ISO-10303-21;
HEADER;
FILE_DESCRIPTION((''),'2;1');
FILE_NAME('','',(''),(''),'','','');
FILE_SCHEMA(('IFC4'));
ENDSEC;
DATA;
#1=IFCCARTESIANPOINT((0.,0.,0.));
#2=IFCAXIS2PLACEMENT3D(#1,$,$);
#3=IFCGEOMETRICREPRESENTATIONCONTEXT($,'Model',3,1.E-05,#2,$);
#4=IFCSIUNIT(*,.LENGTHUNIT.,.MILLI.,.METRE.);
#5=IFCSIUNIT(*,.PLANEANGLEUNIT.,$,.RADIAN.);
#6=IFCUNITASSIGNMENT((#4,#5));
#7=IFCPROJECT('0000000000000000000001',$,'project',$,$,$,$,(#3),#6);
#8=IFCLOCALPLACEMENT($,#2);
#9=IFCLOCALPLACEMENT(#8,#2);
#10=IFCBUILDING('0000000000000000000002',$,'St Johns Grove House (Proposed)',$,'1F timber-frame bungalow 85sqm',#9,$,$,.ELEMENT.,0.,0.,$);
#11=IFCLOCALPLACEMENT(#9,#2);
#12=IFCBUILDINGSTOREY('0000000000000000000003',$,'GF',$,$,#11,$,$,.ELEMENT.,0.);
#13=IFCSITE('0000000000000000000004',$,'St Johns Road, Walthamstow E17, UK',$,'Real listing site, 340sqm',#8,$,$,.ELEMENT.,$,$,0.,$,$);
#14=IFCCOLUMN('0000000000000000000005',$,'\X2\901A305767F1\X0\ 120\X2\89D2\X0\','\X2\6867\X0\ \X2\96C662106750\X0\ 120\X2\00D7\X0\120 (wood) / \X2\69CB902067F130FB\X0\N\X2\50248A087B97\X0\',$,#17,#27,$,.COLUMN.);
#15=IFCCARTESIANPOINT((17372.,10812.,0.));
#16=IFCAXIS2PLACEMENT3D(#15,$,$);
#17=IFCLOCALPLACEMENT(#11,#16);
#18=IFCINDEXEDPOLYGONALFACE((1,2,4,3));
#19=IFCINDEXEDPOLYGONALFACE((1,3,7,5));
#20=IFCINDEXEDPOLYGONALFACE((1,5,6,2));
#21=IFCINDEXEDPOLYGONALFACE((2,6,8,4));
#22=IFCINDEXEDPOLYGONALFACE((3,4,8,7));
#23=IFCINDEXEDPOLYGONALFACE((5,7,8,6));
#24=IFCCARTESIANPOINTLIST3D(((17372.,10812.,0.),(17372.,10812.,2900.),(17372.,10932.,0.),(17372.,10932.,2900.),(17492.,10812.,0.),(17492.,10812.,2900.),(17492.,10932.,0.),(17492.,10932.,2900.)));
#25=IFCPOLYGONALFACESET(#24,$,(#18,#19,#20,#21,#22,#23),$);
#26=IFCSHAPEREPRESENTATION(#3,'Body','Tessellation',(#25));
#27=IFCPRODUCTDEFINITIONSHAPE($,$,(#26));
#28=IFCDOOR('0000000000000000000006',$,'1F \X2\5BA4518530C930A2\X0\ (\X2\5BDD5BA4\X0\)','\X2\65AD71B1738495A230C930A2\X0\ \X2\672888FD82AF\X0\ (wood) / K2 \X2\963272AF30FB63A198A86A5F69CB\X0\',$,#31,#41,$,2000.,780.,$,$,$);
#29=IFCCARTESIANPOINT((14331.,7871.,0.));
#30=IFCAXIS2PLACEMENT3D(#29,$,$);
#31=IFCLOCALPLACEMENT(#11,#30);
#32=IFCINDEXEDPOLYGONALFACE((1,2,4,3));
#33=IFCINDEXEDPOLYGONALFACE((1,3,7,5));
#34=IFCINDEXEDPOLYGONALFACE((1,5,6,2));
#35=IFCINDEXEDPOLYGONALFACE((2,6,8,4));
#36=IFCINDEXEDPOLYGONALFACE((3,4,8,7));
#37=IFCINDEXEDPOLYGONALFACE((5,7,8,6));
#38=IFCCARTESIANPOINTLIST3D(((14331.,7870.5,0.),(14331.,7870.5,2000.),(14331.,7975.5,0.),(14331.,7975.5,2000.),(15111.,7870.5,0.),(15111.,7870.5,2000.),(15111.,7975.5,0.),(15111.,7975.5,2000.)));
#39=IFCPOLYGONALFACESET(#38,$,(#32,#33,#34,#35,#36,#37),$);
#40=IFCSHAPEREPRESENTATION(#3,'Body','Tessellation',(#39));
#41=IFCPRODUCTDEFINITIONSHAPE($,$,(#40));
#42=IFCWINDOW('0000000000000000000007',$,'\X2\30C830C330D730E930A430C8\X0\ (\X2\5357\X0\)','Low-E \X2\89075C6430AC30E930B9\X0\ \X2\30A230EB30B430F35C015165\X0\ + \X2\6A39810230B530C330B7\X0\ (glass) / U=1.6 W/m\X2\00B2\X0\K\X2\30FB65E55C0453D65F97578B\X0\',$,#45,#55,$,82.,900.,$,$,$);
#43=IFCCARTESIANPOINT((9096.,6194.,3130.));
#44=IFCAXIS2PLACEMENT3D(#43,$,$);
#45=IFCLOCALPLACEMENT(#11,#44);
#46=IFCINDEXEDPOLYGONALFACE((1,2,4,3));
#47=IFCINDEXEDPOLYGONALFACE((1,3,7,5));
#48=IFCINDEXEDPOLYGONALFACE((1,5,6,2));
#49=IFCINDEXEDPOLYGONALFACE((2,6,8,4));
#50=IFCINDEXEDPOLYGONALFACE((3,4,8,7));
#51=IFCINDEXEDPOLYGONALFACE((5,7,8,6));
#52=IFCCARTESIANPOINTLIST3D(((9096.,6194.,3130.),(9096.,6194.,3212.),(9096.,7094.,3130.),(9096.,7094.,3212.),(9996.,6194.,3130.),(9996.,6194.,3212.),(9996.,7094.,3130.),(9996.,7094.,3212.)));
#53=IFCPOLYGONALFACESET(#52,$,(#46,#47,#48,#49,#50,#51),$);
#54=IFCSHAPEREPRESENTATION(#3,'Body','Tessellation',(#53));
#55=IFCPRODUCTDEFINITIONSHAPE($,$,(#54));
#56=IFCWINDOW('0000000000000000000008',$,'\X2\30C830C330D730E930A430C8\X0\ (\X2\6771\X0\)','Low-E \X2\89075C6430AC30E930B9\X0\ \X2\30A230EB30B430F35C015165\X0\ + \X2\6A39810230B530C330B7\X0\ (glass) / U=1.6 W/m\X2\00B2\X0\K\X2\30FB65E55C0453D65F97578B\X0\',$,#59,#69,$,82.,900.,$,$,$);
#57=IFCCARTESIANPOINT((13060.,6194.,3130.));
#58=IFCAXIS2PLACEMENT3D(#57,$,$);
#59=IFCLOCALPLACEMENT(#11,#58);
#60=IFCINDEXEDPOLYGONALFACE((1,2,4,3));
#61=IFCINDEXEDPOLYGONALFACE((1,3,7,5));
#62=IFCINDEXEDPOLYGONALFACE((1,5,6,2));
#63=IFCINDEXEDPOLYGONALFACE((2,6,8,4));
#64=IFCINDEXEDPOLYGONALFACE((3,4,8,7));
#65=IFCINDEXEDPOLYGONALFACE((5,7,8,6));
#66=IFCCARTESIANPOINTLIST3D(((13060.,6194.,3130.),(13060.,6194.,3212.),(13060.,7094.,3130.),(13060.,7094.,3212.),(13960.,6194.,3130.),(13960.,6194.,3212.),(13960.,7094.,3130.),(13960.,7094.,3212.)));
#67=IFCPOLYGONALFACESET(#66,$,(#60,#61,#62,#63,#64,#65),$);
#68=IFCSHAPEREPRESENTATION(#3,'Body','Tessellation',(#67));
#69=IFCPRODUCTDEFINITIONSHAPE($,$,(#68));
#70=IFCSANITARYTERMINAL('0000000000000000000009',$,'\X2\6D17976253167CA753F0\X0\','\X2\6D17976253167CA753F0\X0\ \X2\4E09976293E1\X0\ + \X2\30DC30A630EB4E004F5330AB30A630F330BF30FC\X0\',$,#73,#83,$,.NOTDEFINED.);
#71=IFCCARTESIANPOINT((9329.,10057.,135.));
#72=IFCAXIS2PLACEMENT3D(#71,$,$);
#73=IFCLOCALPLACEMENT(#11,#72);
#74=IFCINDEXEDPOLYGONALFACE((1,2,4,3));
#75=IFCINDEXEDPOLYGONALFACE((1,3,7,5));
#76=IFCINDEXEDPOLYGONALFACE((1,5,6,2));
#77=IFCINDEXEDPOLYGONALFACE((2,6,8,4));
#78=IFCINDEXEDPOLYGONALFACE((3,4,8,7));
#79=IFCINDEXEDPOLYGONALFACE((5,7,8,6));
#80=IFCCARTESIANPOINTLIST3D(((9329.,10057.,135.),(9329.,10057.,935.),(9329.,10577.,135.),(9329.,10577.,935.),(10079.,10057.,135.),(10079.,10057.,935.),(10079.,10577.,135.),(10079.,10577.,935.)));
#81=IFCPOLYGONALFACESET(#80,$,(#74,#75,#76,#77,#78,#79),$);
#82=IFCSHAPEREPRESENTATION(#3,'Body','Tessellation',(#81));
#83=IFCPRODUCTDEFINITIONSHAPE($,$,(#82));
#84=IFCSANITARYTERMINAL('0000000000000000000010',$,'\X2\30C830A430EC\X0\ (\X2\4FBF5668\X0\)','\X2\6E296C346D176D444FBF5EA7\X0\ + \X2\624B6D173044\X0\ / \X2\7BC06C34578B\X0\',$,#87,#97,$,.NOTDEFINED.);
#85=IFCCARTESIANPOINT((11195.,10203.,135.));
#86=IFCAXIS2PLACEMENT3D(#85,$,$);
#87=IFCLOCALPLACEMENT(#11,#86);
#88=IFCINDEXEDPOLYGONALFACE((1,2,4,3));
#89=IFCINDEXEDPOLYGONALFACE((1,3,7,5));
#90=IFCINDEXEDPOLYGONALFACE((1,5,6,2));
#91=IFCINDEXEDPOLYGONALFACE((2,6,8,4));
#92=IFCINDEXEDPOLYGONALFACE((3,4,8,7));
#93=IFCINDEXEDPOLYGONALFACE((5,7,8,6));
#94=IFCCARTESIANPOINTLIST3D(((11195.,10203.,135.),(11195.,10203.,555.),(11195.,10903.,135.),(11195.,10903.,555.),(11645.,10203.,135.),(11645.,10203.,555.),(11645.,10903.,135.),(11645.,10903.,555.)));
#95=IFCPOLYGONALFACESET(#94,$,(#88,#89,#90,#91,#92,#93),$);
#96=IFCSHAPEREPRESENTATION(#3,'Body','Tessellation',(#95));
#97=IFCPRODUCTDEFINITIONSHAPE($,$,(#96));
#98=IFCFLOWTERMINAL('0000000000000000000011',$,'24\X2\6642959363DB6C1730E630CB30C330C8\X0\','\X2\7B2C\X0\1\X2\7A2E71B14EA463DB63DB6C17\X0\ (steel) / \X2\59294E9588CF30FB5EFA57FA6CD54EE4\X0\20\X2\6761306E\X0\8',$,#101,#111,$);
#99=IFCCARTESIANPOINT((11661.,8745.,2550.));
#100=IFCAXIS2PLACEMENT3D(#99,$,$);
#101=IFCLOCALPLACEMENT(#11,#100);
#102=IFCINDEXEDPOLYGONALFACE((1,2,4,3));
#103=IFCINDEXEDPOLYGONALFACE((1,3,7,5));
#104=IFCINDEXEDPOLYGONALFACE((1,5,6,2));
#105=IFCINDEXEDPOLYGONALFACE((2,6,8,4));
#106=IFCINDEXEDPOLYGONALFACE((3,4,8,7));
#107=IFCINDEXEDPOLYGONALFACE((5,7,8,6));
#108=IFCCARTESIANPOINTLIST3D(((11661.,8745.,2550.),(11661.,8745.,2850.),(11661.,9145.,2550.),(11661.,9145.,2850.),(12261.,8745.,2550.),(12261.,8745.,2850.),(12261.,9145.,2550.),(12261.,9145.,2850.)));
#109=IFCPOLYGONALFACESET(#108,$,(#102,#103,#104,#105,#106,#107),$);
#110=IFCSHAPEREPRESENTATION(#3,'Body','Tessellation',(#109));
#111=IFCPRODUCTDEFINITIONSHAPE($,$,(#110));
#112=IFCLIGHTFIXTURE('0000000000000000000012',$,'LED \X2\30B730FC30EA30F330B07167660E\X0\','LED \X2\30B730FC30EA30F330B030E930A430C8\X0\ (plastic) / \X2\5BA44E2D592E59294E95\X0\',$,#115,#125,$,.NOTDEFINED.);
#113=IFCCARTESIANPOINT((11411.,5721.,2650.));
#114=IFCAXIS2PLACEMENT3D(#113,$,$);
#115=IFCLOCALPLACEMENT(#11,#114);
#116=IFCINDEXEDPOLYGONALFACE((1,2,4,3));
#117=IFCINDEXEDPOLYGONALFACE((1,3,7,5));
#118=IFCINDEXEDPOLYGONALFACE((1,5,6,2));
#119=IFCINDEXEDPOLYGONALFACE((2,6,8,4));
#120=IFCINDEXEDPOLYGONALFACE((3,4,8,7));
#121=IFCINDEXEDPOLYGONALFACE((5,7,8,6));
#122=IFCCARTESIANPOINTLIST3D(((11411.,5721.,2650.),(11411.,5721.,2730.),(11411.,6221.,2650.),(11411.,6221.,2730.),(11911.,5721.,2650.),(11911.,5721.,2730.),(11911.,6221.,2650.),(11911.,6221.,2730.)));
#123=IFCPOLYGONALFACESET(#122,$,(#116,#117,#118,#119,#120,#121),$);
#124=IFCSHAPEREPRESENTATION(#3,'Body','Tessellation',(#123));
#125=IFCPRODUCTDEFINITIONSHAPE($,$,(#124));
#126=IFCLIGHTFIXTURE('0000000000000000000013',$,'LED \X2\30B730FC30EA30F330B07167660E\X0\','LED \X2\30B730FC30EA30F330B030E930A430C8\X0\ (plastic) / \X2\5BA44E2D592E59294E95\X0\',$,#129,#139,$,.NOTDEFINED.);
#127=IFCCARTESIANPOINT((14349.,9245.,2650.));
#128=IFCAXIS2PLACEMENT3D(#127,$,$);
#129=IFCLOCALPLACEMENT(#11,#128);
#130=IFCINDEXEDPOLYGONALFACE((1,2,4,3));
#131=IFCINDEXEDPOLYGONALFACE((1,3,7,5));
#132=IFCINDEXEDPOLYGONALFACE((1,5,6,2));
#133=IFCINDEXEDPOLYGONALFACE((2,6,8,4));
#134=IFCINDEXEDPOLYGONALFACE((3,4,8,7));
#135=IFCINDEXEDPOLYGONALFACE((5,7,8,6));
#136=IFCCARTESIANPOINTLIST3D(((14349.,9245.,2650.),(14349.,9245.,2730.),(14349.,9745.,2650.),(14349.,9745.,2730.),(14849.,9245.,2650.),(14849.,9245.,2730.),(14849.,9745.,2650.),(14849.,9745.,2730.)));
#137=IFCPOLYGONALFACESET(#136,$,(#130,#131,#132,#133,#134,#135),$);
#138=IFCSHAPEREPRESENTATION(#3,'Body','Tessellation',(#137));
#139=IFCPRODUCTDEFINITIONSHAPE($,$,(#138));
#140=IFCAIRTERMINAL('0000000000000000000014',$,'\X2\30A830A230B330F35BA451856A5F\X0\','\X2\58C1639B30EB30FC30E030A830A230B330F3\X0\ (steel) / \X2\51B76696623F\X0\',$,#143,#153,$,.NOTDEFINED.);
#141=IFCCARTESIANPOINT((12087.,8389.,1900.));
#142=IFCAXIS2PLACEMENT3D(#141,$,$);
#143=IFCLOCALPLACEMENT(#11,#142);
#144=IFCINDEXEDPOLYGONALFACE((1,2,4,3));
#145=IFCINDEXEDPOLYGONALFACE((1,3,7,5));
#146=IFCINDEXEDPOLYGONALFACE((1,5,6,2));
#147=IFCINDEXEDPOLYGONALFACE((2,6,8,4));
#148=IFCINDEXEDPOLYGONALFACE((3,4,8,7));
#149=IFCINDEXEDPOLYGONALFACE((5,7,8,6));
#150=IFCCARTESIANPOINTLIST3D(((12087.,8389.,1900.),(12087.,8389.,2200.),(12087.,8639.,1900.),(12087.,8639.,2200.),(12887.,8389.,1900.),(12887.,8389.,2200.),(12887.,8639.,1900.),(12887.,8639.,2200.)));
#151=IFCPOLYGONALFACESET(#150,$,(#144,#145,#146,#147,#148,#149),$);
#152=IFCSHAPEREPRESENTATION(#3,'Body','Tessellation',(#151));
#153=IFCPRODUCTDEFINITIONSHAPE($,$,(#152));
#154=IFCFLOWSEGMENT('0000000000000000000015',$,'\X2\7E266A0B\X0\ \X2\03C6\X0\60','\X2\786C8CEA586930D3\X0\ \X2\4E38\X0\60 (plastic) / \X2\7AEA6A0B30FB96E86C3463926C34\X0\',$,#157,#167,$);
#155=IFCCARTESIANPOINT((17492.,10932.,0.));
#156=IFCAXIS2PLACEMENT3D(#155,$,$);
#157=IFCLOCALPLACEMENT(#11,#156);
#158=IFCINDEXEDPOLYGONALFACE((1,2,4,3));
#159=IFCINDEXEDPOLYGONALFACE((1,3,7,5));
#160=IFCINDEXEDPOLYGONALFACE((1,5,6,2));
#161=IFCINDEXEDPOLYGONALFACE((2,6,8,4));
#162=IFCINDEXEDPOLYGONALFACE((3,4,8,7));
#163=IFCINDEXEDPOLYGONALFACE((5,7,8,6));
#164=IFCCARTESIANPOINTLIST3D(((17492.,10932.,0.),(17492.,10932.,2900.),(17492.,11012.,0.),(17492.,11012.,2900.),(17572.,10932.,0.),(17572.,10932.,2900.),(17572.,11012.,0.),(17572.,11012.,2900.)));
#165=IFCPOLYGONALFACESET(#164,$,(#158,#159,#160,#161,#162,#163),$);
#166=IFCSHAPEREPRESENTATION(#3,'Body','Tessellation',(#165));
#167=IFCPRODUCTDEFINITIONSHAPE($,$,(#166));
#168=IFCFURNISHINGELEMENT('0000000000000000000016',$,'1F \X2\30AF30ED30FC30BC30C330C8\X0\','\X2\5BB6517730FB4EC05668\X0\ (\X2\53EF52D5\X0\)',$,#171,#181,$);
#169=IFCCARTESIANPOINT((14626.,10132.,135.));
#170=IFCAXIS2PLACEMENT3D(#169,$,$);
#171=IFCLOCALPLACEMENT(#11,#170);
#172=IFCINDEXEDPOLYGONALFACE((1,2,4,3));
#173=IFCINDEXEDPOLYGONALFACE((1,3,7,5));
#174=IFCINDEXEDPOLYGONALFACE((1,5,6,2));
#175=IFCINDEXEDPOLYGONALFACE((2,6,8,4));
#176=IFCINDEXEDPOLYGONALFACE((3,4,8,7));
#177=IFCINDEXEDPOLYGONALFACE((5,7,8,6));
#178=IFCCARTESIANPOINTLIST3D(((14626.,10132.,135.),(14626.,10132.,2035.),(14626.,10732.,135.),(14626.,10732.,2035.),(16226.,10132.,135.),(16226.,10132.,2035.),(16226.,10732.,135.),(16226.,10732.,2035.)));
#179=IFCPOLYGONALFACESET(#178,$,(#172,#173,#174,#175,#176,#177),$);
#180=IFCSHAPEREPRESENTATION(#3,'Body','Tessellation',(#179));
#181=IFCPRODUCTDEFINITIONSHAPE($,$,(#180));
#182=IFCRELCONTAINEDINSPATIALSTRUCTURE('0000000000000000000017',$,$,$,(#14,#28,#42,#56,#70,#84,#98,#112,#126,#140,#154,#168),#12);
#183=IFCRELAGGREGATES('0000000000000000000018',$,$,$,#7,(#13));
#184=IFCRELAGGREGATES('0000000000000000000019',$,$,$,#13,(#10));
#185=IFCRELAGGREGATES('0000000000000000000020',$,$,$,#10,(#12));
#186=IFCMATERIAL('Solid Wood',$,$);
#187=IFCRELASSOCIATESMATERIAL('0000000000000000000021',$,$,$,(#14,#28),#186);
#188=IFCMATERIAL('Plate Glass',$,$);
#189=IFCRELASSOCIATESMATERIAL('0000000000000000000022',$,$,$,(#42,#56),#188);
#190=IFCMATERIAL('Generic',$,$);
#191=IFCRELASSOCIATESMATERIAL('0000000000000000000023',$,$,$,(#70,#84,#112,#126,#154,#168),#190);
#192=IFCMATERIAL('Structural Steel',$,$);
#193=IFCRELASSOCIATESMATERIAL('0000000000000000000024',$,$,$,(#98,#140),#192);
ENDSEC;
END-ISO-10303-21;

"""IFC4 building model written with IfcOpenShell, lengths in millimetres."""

from ifc_helpers import new_model, si_unit, frame, frame_2d, origin, place, context, project, spatial, rectangle, extrude, material, element, save


model = new_model("IFC4")

# Units and contexts
model_context = context("Model", 3, precision=1e-05, world=origin())
ifc_project = project(units=[si_unit("LENGTHUNIT", "METRE", prefix="MILLI"), si_unit("PLANEANGLEUNIT", "RADIAN")], contexts=[model_context])

# Site, building, storey
site_placement = place(None, origin())
site = spatial("IfcSite", under=ifc_project, at=site_placement, Name="St Johns Road, Walthamstow E17, UK", ObjectType="Real listing site, 340sqm", CompositionType="ELEMENT", RefElevation=0.0)
building_placement = place(site_placement, origin())
building = spatial("IfcBuilding", under=site, at=building_placement, Name="St Johns Grove House (Proposed)", ObjectType="1F timber-frame bungalow 85sqm", CompositionType="ELEMENT", ElevationOfRefHeight=0.0, ElevationOfTerrain=0.0)
storey_placement = place(building_placement, origin())
storey = spatial("IfcBuildingStorey", under=building, at=storey_placement, Name="GF", CompositionType="ELEMENT", Elevation=0.0)

# Column
ifc_material_1 = material(Name="Solid Wood")
column_1_placement = place(storey_placement, frame((17372.0, 10812.0, 0.0)))
element("IfcColumn", 1, at=column_1_placement, inside=storey, material=ifc_material_1, Name="通し柱 120角", Description="桧 集成材 120×120 (wood) / 構造柱・N値計算", PredefinedType="COLUMN", context=model_context, shape_type="SweptSolid", body=[
    extrude(rectangle(XDim=120.0, YDim=120.0, at=frame_2d((60.0, 60.0))), frame((17372.0, 10812.0, 0.0)), (0.0, 0.0, 1.0), 2900.0),
])

# Door
door_placement = place(storey_placement, frame((14331.0, 7871.0, 0.0)))
element("IfcDoor", 2, at=door_placement, inside=storey, material=ifc_material_1, Name="1F 室内ドア (寝室)", Description="断熱玄関ドア 木製芯 (wood) / K2 防犯・採風機構", OverallHeight=2000.0, OverallWidth=780.0, context=model_context, shape_type="SweptSolid", body=[
    extrude(rectangle(XDim=780.0, YDim=105.0, at=frame_2d((390.0, 52.0))), frame((14331.0, 7871.0, 0.0)), (0.0, 0.0, 1.0), 2000.0),
])

# Windows
ifc_material_2 = material(Name="Plate Glass")
window_1_placement = place(storey_placement, frame((9096.0, 6194.0, 3130.0)))
element("IfcWindow", 3, at=window_1_placement, inside=storey, material=ifc_material_2, Name="トップライト (南)", Description="Low-E 複層ガラス アルゴン封入 + 樹脂サッシ (glass) / U=1.6 W/m²K・日射取得型", OverallHeight=82.0, OverallWidth=900.0, context=model_context, shape_type="SweptSolid", body=[
    extrude(rectangle(XDim=900.0, YDim=900.0, at=frame_2d((450.0, 450.0))), frame((9096.0, 6194.0, 3130.0)), (0.0, 0.0, 1.0), 82.0),
])
window_2_placement = place(storey_placement, frame((13060.0, 6194.0, 3130.0)))
element("IfcWindow", 4, at=window_2_placement, inside=storey, material=ifc_material_2, Name="トップライト (東)", Description="Low-E 複層ガラス アルゴン封入 + 樹脂サッシ (glass) / U=1.6 W/m²K・日射取得型", OverallHeight=82.0, OverallWidth=900.0, context=model_context, shape_type="SweptSolid", body=[
    extrude(rectangle(XDim=900.0, YDim=900.0, at=frame_2d((450.0, 450.0))), frame((13060.0, 6194.0, 3130.0)), (0.0, 0.0, 1.0), 82.0),
])

# Sanitary terminals
ifc_material_3 = material(Name="Generic")
sanitary_terminal_1_placement = place(storey_placement, frame((9329.0, 10057.0, 135.0)))
element("IfcSanitaryTerminal", 5, at=sanitary_terminal_1_placement, inside=storey, material=ifc_material_3, Name="洗面化粧台", Description="洗面化粧台 三面鏡 + ボウル一体カウンター", PredefinedType="NOTDEFINED", context=model_context, shape_type="SweptSolid", body=[
    extrude(rectangle(XDim=750.0, YDim=520.0, at=frame_2d((375.0, 260.0))), frame((9329.0, 10057.0, 135.0)), (0.0, 0.0, 1.0), 800.0),
])
sanitary_terminal_2_placement = place(storey_placement, frame((11195.0, 10203.0, 135.0)))
element("IfcSanitaryTerminal", 6, at=sanitary_terminal_2_placement, inside=storey, material=ifc_material_3, Name="トイレ (便器)", Description="温水洗浄便座 + 手洗い / 節水型", PredefinedType="NOTDEFINED", context=model_context, shape_type="SweptSolid", body=[
    extrude(rectangle(XDim=450.0, YDim=700.0, at=frame_2d((225.0, 350.0))), frame((11195.0, 10203.0, 135.0)), (0.0, 0.0, 1.0), 420.0),
])

# Flow terminal
ifc_material_4 = material(Name="Structural Steel")
flow_terminal_placement = place(storey_placement, frame((11661.0, 8745.0, 2550.0)))
element("IfcFlowTerminal", 7, at=flow_terminal_placement, inside=storey, material=ifc_material_4, Name="24時間換気ユニット", Description="第1種熱交換換気 (steel) / 天井裏・建基法令20条の8", context=model_context, shape_type="SweptSolid", body=[
    extrude(rectangle(XDim=600.0, YDim=400.0, at=frame_2d((300.0, 200.0))), frame((11661.0, 8745.0, 2550.0)), (0.0, 0.0, 1.0), 300.0),
])

# Light fixtures
light_fixture_1_placement = place(storey_placement, frame((11411.0, 5721.0, 2650.0)))
element("IfcLightFixture", 8, at=light_fixture_1_placement, inside=storey, material=ifc_material_3, Name="LED シーリング照明", Description="LED シーリングライト (plastic) / 室中央天井", PredefinedType="NOTDEFINED", context=model_context, shape_type="SweptSolid", body=[
    extrude(rectangle(XDim=500.0, YDim=500.0, at=frame_2d((250.0, 250.0))), frame((11411.0, 5721.0, 2650.0)), (0.0, 0.0, 1.0), 80.0),
])
light_fixture_2_placement = place(storey_placement, frame((14349.0, 9245.0, 2650.0)))
element("IfcLightFixture", 9, at=light_fixture_2_placement, inside=storey, material=ifc_material_3, Name="LED シーリング照明", Description="LED シーリングライト (plastic) / 室中央天井", PredefinedType="NOTDEFINED", context=model_context, shape_type="SweptSolid", body=[
    extrude(rectangle(XDim=500.0, YDim=500.0, at=frame_2d((250.0, 250.0))), frame((14349.0, 9245.0, 2650.0)), (0.0, 0.0, 1.0), 80.0),
])

# Air terminal
air_terminal_placement = place(storey_placement, frame((12087.0, 8389.0, 1900.0)))
element("IfcAirTerminal", 10, at=air_terminal_placement, inside=storey, material=ifc_material_4, Name="エアコン室内機", Description="壁掛ルームエアコン (steel) / 冷暖房", PredefinedType="NOTDEFINED", context=model_context, shape_type="SweptSolid", body=[
    extrude(rectangle(XDim=800.0, YDim=250.0, at=frame_2d((400.0, 125.0))), frame((12087.0, 8389.0, 1900.0)), (0.0, 0.0, 1.0), 300.0),
])

# Flow segment
flow_segment_placement = place(storey_placement, frame((17492.0, 10932.0, 0.0)))
element("IfcFlowSegment", 11, at=flow_segment_placement, inside=storey, material=ifc_material_3, Name="縦樋 φ60", Description="硬質塩ビ 丸60 (plastic) / 竪樋・雨水排水", context=model_context, shape_type="SweptSolid", body=[
    extrude(rectangle(XDim=80.0, YDim=80.0, at=frame_2d((40.0, 40.0))), frame((17492.0, 10932.0, 0.0)), (0.0, 0.0, 1.0), 2900.0),
])

# Furnishing element
furnishing_placement = place(storey_placement, frame((14626.0, 10132.0, 135.0)))
element("IfcFurnishingElement", 12, at=furnishing_placement, inside=storey, material=ifc_material_3, Name="1F クローゼット", Description="家具・什器 (可動)", context=model_context, shape_type="SweptSolid", body=[
    extrude(rectangle(XDim=1600.0, YDim=600.0, at=frame_2d((800.0, 300.0))), frame((14626.0, 10132.0, 135.0)), (0.0, 0.0, 1.0), 1900.0),
])

save(model, "model.ifc")
